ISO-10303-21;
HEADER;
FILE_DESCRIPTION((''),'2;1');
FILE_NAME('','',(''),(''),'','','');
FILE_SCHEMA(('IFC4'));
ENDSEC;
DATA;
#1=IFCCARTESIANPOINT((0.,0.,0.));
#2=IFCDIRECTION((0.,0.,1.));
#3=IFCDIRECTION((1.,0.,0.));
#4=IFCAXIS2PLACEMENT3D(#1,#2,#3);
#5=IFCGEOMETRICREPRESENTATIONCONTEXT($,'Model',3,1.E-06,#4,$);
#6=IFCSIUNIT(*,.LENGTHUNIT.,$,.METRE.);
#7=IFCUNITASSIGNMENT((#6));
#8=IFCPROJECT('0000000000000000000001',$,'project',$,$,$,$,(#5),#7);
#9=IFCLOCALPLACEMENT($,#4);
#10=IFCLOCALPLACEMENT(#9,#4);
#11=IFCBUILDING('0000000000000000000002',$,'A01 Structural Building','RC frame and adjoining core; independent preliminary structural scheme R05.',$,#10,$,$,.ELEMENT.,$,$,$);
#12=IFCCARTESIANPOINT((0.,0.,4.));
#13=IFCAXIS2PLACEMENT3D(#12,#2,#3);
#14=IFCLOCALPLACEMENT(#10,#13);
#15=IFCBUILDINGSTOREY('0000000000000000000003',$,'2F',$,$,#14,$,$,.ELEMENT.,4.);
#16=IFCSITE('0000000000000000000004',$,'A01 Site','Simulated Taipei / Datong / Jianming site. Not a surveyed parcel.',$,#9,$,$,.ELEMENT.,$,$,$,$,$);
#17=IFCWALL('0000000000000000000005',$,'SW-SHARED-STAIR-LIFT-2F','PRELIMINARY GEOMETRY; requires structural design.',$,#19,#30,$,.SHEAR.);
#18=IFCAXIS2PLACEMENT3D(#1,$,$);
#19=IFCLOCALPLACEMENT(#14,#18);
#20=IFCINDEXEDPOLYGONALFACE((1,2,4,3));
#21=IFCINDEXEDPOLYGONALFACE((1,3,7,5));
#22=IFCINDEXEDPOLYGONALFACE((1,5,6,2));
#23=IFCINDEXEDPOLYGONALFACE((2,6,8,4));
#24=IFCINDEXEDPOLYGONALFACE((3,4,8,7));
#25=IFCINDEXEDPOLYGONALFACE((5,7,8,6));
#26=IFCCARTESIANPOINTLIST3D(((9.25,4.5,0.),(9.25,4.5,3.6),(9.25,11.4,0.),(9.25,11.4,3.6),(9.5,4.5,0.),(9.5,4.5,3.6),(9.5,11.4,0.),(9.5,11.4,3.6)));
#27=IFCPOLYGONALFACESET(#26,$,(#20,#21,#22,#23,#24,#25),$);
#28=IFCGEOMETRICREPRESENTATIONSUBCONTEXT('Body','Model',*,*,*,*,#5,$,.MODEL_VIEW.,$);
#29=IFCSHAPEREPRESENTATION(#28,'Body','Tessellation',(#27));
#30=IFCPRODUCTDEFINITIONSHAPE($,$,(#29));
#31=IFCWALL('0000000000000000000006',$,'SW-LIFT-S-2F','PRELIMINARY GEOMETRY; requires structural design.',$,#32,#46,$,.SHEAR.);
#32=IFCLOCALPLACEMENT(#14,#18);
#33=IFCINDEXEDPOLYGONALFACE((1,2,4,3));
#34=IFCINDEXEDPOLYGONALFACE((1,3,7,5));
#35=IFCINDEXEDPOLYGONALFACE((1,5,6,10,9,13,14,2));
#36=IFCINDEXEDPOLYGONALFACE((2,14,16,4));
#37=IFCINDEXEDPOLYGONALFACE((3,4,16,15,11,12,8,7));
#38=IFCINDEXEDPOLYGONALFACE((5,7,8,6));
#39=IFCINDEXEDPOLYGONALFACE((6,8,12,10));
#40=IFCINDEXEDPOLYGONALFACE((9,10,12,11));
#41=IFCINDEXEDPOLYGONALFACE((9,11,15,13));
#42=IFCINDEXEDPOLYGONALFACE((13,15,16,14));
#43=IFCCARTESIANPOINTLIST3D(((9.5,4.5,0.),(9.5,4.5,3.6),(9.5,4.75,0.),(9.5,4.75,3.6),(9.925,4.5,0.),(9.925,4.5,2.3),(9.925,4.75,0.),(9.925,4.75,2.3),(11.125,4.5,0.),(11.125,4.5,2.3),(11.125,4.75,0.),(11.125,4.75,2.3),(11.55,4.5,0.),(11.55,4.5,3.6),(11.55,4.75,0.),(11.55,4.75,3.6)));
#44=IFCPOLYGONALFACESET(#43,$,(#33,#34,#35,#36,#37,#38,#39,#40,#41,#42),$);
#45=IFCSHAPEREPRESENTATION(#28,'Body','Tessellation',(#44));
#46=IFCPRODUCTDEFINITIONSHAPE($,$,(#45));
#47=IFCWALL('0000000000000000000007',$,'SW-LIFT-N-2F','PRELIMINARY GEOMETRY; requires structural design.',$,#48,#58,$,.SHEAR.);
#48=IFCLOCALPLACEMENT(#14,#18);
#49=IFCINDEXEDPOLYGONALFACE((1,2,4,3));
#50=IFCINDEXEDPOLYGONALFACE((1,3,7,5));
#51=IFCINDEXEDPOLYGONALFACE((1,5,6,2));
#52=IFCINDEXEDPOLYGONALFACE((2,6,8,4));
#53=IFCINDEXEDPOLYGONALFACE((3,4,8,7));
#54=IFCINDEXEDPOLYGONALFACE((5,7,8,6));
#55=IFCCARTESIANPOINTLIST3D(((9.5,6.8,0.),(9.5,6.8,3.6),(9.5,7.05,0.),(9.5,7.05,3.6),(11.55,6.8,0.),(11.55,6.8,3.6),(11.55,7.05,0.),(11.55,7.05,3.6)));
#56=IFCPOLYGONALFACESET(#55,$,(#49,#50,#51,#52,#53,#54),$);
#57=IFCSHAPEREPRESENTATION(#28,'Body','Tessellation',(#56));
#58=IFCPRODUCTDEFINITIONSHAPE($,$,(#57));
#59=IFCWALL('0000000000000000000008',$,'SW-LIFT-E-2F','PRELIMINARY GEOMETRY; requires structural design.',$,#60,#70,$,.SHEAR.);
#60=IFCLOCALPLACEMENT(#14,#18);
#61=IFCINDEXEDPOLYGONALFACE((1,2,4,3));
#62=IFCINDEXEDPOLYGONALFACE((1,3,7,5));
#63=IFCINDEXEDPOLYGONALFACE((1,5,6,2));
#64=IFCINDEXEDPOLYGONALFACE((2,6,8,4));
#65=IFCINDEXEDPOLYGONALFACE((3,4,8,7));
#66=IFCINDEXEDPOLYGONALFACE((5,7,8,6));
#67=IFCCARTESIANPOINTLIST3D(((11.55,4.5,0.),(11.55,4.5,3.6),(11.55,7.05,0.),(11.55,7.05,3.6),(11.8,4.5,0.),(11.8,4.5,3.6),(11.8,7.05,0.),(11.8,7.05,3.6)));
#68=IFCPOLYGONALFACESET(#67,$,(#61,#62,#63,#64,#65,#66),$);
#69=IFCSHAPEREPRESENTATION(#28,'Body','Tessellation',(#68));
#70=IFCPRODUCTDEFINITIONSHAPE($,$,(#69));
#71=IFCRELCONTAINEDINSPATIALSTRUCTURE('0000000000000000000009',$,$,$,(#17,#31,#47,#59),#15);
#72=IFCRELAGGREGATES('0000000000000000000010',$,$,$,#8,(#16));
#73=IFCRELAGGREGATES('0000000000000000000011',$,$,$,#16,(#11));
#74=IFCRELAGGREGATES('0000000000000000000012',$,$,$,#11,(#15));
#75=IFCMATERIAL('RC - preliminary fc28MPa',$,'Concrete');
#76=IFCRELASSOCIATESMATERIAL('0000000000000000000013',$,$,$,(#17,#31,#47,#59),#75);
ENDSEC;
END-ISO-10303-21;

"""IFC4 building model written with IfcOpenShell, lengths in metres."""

from ifc_helpers import new_model, si_unit, frame, origin_with_axes, place, context, subcontext, project, spatial, rectangle, extrude, material, element, save


model = new_model("IFC4")

# Units and contexts
model_context = context("Model", 3, precision=1e-06, world=origin_with_axes())
body_context = subcontext(model_context, "Body", "Model", "MODEL_VIEW")
ifc_project = project(units=[si_unit("LENGTHUNIT", "METRE")], contexts=[model_context])

# Site, building, storey
site_placement = place(None, origin_with_axes())
site = spatial("IfcSite", under=ifc_project, at=site_placement, Name="A01 Site", Description="Simulated Taipei / Datong / Jianming site. Not a surveyed parcel.", CompositionType="ELEMENT")
building_placement = place(site_placement, origin_with_axes())
building = spatial("IfcBuilding", under=site, at=building_placement, Name="A01 Structural Building", Description="RC frame and adjoining core; independent preliminary structural scheme R05.", CompositionType="ELEMENT")
storey_placement = place(building_placement, frame((0.0, 0.0, 4.0), z_axis=(0.0, 0.0, 1.0), x_axis=(1.0, 0.0, 0.0)))
storey = spatial("IfcBuildingStorey", under=building, at=storey_placement, Name="2F", CompositionType="ELEMENT", Elevation=4.0)

# Shared definitions
ifc_material = material(Name="RC - preliminary fc28MPa", Category="Concrete")

# Wall
wall_1_placement = place(storey_placement, frame((9.375, 7.95, 0.0), z_axis=(0.0, 0.0, 1.0), x_axis=(1.0, 0.0, 0.0)))
element("IfcWall", 1, at=wall_1_placement, inside=storey, material=ifc_material, Name="SW-SHARED-STAIR-LIFT-2F", Description="PRELIMINARY GEOMETRY; requires structural design.", PredefinedType="SHEAR", context=body_context, shape_type="SweptSolid", body=[
    extrude(rectangle(XDim=0.25, YDim=6.9), origin_with_axes(), (0.0, 0.0, 1.0), 3.6),
])

# Wall, opening
wall_2_placement = place(storey_placement, frame((10.525, 4.625, 0.0), z_axis=(0.0, 0.0, 1.0), x_axis=(1.0, 0.0, 0.0)))
wall_2 = element("IfcWall", 2, at=wall_2_placement, inside=storey, material=ifc_material, Name="SW-LIFT-S-2F", Description="PRELIMINARY GEOMETRY; requires structural design.", PredefinedType="SHEAR", context=body_context, shape_type="SweptSolid", body=[
    extrude(rectangle(XDim=2.05, YDim=0.25), origin_with_axes(), (0.0, 0.0, 1.0), 3.6),
])
opening_1_placement = place(storey_placement, frame((10.525, 4.625, 0.0), z_axis=(0.0, 0.0, 1.0), x_axis=(1.0, 0.0, 0.0)))
element("IfcOpeningElement", 3, at=opening_1_placement, cuts=wall_2, PredefinedType="OPENING", context=body_context, shape_type="SweptSolid", body=[
    extrude(rectangle(XDim=1.2, YDim=0.45), origin_with_axes(), (0.0, 0.0, 1.0), 2.3),
])

# Walls
wall_3_placement = place(storey_placement, frame((10.525, 6.925, 0.0), z_axis=(0.0, 0.0, 1.0), x_axis=(1.0, 0.0, 0.0)))
element("IfcWall", 4, at=wall_3_placement, inside=storey, material=ifc_material, Name="SW-LIFT-N-2F", Description="PRELIMINARY GEOMETRY; requires structural design.", PredefinedType="SHEAR", context=body_context, shape_type="SweptSolid", body=[
    extrude(rectangle(XDim=2.05, YDim=0.25), origin_with_axes(), (0.0, 0.0, 1.0), 3.6),
])
wall_4_placement = place(storey_placement, frame((11.675, 5.775, 0.0), z_axis=(0.0, 0.0, 1.0), x_axis=(1.0, 0.0, 0.0)))
element("IfcWall", 5, at=wall_4_placement, inside=storey, material=ifc_material, Name="SW-LIFT-E-2F", Description="PRELIMINARY GEOMETRY; requires structural design.", PredefinedType="SHEAR", context=body_context, shape_type="SweptSolid", body=[
    extrude(rectangle(XDim=0.25, YDim=2.55), origin_with_axes(), (0.0, 0.0, 1.0), 3.6),
])

save(model, "model.ifc")
